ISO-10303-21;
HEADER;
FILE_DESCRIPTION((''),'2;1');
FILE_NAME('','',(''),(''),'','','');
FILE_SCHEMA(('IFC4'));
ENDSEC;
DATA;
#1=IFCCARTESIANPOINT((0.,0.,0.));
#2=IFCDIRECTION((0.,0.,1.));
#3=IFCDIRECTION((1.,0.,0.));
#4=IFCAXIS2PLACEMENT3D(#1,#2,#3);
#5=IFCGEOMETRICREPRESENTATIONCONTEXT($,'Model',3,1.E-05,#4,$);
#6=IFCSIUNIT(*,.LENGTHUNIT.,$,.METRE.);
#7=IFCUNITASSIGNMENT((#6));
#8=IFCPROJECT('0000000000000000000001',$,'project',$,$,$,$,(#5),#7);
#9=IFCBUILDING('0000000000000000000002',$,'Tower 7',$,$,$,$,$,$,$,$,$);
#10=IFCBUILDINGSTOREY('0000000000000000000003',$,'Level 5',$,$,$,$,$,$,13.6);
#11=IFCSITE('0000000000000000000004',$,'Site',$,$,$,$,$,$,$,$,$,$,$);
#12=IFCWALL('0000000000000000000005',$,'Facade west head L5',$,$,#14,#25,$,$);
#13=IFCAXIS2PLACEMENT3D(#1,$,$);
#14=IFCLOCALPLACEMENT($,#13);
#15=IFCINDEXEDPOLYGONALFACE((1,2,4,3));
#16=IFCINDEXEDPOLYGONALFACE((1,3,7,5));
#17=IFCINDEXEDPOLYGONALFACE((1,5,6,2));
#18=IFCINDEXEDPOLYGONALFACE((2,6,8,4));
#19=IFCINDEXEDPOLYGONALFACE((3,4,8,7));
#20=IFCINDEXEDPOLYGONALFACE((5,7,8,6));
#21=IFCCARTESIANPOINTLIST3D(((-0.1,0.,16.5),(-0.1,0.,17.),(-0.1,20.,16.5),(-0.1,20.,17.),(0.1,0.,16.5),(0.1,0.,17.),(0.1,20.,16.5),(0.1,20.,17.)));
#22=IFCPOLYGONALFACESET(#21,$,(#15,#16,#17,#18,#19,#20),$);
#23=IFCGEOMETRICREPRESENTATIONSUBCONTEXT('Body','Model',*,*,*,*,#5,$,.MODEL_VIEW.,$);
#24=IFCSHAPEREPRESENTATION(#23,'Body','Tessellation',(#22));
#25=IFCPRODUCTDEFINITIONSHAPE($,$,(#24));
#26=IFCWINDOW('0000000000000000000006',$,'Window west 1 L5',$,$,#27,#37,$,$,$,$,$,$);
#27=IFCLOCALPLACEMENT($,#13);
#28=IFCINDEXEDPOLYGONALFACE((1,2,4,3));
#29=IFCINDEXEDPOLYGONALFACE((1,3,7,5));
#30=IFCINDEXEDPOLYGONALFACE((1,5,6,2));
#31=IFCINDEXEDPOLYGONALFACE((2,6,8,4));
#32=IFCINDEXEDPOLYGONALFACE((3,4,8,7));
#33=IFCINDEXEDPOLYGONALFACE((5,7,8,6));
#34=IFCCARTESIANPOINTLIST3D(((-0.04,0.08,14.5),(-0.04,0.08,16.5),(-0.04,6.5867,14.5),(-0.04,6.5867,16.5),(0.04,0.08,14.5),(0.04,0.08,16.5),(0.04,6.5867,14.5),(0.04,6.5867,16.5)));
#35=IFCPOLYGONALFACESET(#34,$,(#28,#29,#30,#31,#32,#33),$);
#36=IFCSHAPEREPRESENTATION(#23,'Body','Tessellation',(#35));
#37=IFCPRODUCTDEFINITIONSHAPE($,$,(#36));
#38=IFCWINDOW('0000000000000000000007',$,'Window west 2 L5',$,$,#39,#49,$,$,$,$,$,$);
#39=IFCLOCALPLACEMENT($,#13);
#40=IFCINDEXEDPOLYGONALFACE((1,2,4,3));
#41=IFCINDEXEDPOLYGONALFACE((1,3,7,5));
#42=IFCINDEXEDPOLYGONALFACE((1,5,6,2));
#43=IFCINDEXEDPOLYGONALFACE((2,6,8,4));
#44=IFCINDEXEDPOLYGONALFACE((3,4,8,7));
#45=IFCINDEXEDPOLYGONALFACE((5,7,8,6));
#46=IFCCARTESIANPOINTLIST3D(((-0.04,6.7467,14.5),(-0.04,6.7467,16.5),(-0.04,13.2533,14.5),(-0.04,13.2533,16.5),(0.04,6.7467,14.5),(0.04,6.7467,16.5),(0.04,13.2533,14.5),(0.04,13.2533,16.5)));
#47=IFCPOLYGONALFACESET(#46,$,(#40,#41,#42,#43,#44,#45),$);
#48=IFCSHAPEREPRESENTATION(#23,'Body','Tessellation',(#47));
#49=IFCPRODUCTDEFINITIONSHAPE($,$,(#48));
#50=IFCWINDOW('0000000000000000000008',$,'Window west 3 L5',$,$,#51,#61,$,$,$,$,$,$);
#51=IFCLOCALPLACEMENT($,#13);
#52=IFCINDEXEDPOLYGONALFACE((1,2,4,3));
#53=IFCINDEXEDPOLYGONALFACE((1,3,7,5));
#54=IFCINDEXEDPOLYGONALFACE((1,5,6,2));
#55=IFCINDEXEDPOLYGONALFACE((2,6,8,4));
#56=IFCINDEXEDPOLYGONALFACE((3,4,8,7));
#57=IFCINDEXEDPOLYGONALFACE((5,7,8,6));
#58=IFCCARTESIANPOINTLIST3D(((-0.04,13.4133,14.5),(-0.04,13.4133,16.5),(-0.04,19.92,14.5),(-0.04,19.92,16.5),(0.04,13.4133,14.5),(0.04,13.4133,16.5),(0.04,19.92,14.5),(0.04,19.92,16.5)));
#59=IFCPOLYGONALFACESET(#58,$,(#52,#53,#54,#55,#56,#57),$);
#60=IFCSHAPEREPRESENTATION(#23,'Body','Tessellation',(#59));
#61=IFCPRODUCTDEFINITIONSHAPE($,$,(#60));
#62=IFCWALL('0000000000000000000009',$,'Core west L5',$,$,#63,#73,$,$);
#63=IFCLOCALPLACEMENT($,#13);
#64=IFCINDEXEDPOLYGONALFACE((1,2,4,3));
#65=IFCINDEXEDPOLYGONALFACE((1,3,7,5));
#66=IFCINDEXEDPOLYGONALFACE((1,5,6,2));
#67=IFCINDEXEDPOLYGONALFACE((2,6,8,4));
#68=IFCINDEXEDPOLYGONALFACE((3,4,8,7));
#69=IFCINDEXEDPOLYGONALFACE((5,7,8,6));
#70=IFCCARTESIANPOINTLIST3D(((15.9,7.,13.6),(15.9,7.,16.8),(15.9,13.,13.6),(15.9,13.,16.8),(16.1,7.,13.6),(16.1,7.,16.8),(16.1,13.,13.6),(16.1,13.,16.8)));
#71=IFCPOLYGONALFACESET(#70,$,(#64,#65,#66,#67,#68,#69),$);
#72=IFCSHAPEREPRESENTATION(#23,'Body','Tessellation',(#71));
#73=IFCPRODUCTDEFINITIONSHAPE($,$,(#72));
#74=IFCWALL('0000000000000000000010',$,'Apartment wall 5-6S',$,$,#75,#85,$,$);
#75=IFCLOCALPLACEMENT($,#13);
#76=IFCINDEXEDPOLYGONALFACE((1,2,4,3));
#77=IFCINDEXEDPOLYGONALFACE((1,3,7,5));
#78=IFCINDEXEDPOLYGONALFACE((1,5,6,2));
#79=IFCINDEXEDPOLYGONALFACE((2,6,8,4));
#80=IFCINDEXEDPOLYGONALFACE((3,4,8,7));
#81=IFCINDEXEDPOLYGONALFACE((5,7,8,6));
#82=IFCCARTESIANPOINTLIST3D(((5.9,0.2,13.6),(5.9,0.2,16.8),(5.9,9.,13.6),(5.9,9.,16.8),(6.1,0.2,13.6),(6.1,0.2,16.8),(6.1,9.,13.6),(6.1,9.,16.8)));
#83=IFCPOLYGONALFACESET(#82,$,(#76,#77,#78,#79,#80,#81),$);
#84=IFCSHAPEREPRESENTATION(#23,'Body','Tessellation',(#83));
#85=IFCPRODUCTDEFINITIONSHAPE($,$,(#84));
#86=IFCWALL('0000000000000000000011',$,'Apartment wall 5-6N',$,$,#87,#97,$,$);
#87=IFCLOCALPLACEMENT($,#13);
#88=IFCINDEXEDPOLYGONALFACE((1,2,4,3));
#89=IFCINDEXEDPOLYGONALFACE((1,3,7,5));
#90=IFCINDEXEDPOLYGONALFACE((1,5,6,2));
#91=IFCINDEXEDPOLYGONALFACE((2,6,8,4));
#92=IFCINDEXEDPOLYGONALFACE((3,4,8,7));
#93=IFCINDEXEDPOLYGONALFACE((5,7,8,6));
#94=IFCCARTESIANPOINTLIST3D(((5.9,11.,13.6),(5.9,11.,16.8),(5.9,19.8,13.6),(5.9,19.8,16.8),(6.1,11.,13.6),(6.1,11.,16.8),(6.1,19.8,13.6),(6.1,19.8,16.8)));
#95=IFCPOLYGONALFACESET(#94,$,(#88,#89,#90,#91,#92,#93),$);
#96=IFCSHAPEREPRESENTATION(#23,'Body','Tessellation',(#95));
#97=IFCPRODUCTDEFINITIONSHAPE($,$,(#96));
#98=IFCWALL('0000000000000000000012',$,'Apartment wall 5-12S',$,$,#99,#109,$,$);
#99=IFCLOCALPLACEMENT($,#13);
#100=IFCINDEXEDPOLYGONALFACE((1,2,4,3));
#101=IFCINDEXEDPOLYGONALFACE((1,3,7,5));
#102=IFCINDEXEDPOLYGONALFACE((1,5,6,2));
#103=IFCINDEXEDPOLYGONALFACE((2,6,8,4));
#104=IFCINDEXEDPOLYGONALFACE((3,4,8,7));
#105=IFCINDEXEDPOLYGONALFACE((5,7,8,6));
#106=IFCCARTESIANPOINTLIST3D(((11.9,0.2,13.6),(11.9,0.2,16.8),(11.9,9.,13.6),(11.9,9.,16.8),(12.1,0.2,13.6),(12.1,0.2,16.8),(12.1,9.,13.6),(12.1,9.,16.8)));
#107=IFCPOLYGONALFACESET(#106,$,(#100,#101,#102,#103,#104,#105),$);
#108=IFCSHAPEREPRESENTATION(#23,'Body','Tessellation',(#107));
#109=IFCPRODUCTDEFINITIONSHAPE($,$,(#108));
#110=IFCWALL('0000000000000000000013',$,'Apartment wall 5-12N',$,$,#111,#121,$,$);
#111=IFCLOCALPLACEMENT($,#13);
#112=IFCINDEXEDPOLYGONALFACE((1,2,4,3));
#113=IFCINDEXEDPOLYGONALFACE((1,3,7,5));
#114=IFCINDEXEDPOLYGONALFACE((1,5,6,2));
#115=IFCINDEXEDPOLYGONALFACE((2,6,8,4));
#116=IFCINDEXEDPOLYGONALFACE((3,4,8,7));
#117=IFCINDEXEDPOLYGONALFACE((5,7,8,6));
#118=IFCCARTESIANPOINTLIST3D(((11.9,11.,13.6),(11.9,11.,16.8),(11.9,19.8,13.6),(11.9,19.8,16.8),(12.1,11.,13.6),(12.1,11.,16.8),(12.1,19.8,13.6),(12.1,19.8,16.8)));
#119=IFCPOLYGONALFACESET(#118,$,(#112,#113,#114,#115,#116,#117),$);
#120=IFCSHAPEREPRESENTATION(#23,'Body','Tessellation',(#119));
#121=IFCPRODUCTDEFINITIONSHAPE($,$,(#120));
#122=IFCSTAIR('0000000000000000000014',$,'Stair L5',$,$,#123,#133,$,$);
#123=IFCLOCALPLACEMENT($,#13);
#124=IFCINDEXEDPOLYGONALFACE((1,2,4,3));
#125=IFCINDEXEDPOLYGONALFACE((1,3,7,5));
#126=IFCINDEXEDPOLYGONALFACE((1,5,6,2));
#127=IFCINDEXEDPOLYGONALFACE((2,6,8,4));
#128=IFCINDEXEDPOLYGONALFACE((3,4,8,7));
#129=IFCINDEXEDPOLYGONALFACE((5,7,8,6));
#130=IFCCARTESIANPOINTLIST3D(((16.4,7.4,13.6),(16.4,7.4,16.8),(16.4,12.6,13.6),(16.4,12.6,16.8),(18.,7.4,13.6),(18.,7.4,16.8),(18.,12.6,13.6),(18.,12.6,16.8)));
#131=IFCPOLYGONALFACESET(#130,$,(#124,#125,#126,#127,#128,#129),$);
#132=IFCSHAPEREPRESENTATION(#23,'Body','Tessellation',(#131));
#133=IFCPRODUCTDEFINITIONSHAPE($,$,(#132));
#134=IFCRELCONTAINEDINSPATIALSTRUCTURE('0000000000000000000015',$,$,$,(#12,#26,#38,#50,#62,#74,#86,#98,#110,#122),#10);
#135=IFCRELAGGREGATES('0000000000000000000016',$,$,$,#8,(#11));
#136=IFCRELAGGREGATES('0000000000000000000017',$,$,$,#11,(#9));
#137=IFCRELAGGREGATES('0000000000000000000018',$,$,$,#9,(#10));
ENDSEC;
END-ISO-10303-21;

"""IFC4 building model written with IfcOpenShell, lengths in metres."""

from ifc_helpers import new_model, si_unit, frame, origin, origin_with_axes, origin_2d, place, context, subcontext, project, spatial, rectangle, extrude, element, save


model = new_model("IFC4")

# Units and contexts
model_context = context("Model", 3, precision=1e-05, world=origin_with_axes())
body_context = subcontext(model_context, "Body", "Model", "MODEL_VIEW")
ifc_project = project(units=[si_unit("LENGTHUNIT", "METRE")], contexts=[model_context])

# Site, building, storey
site = spatial("IfcSite", under=ifc_project, Name="Site")
building = spatial("IfcBuilding", under=site, Name="Tower 7")
storey = spatial("IfcBuildingStorey", under=building, Name="Level 5", Elevation=13.6)

# Wall
wall_1_placement = place(None, frame((0.0, 10.0, 16.5), z_axis=(0.0, 0.0, 1.0), x_axis=(1.0, 0.0, 0.0)))
element("IfcWall", 1, at=wall_1_placement, inside=storey, Name="Facade west head L5", context=body_context, shape_type="SweptSolid", body=[
    extrude(rectangle(XDim=0.2, YDim=20.0, at=origin_2d()), origin(), (0.0, 0.0, 1.0), 0.5),
])

# Windows
for number, where, z_axis, x_axis, name in (
    (2, (0.0, 3.3333, 14.5), (0.0, 0.0, 1.0), (1.0, 0.0, 0.0), "Window west 1 L5"),
    (3, (0.0, 10.0, 14.5), (0.0, 0.0, 1.0), (1.0, 0.0, 0.0), "Window west 2 L5"),
):
    element("IfcWindow", number, at=place(None, frame(where, z_axis=z_axis, x_axis=x_axis)), inside=storey, Name=name, context=body_context, shape_type="SweptSolid", body=[
        extrude(rectangle(XDim=0.08, YDim=6.5067, at=origin_2d()), origin(), (0.0, 0.0, 1.0), 2.0),
    ])
window_1_placement = place(None, frame((0.0, 16.6667, 14.5), z_axis=(0.0, 0.0, 1.0), x_axis=(1.0, 0.0, 0.0)))
element("IfcWindow", 4, at=window_1_placement, inside=storey, Name="Window west 3 L5", context=body_context, shape_type="SweptSolid", body=[
    extrude(rectangle(XDim=0.08, YDim=6.5067, at=origin_2d()), origin(), (0.0, 0.0, 1.0), 2.0),
])

# Walls
wall_2_placement = place(None, frame((16.0, 10.0, 13.6), z_axis=(0.0, 0.0, 1.0), x_axis=(1.0, 0.0, 0.0)))
element("IfcWall", 5, at=wall_2_placement, inside=storey, Name="Core west L5", context=body_context, shape_type="SweptSolid", body=[
    extrude(rectangle(XDim=0.2, YDim=6.0, at=origin_2d()), origin(), (0.0, 0.0, 1.0), 3.2),
])
for number, where, z_axis, x_axis, name in (
    (6, (6.0, 4.6, 13.6), (0.0, 0.0, 1.0), (1.0, 0.0, 0.0), "Apartment wall 5-6S"),
    (7, (6.0, 15.4, 13.6), (0.0, 0.0, 1.0), (1.0, 0.0, 0.0), "Apartment wall 5-6N"),
    (8, (12.0, 4.6, 13.6), (0.0, 0.0, 1.0), (1.0, 0.0, 0.0), "Apartment wall 5-12S"),
    (9, (12.0, 15.4, 13.6), (0.0, 0.0, 1.0), (1.0, 0.0, 0.0), "Apartment wall 5-12N"),
):
    element("IfcWall", number, at=place(None, frame(where, z_axis=z_axis, x_axis=x_axis)), inside=storey, Name=name, context=body_context, shape_type="SweptSolid", body=[
        extrude(rectangle(XDim=0.2, YDim=8.8, at=origin_2d()), origin(), (0.0, 0.0, 1.0), 3.2),
    ])

# Stair
stair_placement = place(None, frame((17.2, 10.0, 13.6), z_axis=(0.0, 0.0, 1.0), x_axis=(1.0, 0.0, 0.0)))
element("IfcStair", 10, at=stair_placement, inside=storey, Name="Stair L5", context=body_context, shape_type="SweptSolid", body=[
    extrude(rectangle(XDim=1.6, YDim=5.2, at=origin_2d()), origin(), (0.0, 0.0, 1.0), 3.2),
])

save(model, "model.ifc")
